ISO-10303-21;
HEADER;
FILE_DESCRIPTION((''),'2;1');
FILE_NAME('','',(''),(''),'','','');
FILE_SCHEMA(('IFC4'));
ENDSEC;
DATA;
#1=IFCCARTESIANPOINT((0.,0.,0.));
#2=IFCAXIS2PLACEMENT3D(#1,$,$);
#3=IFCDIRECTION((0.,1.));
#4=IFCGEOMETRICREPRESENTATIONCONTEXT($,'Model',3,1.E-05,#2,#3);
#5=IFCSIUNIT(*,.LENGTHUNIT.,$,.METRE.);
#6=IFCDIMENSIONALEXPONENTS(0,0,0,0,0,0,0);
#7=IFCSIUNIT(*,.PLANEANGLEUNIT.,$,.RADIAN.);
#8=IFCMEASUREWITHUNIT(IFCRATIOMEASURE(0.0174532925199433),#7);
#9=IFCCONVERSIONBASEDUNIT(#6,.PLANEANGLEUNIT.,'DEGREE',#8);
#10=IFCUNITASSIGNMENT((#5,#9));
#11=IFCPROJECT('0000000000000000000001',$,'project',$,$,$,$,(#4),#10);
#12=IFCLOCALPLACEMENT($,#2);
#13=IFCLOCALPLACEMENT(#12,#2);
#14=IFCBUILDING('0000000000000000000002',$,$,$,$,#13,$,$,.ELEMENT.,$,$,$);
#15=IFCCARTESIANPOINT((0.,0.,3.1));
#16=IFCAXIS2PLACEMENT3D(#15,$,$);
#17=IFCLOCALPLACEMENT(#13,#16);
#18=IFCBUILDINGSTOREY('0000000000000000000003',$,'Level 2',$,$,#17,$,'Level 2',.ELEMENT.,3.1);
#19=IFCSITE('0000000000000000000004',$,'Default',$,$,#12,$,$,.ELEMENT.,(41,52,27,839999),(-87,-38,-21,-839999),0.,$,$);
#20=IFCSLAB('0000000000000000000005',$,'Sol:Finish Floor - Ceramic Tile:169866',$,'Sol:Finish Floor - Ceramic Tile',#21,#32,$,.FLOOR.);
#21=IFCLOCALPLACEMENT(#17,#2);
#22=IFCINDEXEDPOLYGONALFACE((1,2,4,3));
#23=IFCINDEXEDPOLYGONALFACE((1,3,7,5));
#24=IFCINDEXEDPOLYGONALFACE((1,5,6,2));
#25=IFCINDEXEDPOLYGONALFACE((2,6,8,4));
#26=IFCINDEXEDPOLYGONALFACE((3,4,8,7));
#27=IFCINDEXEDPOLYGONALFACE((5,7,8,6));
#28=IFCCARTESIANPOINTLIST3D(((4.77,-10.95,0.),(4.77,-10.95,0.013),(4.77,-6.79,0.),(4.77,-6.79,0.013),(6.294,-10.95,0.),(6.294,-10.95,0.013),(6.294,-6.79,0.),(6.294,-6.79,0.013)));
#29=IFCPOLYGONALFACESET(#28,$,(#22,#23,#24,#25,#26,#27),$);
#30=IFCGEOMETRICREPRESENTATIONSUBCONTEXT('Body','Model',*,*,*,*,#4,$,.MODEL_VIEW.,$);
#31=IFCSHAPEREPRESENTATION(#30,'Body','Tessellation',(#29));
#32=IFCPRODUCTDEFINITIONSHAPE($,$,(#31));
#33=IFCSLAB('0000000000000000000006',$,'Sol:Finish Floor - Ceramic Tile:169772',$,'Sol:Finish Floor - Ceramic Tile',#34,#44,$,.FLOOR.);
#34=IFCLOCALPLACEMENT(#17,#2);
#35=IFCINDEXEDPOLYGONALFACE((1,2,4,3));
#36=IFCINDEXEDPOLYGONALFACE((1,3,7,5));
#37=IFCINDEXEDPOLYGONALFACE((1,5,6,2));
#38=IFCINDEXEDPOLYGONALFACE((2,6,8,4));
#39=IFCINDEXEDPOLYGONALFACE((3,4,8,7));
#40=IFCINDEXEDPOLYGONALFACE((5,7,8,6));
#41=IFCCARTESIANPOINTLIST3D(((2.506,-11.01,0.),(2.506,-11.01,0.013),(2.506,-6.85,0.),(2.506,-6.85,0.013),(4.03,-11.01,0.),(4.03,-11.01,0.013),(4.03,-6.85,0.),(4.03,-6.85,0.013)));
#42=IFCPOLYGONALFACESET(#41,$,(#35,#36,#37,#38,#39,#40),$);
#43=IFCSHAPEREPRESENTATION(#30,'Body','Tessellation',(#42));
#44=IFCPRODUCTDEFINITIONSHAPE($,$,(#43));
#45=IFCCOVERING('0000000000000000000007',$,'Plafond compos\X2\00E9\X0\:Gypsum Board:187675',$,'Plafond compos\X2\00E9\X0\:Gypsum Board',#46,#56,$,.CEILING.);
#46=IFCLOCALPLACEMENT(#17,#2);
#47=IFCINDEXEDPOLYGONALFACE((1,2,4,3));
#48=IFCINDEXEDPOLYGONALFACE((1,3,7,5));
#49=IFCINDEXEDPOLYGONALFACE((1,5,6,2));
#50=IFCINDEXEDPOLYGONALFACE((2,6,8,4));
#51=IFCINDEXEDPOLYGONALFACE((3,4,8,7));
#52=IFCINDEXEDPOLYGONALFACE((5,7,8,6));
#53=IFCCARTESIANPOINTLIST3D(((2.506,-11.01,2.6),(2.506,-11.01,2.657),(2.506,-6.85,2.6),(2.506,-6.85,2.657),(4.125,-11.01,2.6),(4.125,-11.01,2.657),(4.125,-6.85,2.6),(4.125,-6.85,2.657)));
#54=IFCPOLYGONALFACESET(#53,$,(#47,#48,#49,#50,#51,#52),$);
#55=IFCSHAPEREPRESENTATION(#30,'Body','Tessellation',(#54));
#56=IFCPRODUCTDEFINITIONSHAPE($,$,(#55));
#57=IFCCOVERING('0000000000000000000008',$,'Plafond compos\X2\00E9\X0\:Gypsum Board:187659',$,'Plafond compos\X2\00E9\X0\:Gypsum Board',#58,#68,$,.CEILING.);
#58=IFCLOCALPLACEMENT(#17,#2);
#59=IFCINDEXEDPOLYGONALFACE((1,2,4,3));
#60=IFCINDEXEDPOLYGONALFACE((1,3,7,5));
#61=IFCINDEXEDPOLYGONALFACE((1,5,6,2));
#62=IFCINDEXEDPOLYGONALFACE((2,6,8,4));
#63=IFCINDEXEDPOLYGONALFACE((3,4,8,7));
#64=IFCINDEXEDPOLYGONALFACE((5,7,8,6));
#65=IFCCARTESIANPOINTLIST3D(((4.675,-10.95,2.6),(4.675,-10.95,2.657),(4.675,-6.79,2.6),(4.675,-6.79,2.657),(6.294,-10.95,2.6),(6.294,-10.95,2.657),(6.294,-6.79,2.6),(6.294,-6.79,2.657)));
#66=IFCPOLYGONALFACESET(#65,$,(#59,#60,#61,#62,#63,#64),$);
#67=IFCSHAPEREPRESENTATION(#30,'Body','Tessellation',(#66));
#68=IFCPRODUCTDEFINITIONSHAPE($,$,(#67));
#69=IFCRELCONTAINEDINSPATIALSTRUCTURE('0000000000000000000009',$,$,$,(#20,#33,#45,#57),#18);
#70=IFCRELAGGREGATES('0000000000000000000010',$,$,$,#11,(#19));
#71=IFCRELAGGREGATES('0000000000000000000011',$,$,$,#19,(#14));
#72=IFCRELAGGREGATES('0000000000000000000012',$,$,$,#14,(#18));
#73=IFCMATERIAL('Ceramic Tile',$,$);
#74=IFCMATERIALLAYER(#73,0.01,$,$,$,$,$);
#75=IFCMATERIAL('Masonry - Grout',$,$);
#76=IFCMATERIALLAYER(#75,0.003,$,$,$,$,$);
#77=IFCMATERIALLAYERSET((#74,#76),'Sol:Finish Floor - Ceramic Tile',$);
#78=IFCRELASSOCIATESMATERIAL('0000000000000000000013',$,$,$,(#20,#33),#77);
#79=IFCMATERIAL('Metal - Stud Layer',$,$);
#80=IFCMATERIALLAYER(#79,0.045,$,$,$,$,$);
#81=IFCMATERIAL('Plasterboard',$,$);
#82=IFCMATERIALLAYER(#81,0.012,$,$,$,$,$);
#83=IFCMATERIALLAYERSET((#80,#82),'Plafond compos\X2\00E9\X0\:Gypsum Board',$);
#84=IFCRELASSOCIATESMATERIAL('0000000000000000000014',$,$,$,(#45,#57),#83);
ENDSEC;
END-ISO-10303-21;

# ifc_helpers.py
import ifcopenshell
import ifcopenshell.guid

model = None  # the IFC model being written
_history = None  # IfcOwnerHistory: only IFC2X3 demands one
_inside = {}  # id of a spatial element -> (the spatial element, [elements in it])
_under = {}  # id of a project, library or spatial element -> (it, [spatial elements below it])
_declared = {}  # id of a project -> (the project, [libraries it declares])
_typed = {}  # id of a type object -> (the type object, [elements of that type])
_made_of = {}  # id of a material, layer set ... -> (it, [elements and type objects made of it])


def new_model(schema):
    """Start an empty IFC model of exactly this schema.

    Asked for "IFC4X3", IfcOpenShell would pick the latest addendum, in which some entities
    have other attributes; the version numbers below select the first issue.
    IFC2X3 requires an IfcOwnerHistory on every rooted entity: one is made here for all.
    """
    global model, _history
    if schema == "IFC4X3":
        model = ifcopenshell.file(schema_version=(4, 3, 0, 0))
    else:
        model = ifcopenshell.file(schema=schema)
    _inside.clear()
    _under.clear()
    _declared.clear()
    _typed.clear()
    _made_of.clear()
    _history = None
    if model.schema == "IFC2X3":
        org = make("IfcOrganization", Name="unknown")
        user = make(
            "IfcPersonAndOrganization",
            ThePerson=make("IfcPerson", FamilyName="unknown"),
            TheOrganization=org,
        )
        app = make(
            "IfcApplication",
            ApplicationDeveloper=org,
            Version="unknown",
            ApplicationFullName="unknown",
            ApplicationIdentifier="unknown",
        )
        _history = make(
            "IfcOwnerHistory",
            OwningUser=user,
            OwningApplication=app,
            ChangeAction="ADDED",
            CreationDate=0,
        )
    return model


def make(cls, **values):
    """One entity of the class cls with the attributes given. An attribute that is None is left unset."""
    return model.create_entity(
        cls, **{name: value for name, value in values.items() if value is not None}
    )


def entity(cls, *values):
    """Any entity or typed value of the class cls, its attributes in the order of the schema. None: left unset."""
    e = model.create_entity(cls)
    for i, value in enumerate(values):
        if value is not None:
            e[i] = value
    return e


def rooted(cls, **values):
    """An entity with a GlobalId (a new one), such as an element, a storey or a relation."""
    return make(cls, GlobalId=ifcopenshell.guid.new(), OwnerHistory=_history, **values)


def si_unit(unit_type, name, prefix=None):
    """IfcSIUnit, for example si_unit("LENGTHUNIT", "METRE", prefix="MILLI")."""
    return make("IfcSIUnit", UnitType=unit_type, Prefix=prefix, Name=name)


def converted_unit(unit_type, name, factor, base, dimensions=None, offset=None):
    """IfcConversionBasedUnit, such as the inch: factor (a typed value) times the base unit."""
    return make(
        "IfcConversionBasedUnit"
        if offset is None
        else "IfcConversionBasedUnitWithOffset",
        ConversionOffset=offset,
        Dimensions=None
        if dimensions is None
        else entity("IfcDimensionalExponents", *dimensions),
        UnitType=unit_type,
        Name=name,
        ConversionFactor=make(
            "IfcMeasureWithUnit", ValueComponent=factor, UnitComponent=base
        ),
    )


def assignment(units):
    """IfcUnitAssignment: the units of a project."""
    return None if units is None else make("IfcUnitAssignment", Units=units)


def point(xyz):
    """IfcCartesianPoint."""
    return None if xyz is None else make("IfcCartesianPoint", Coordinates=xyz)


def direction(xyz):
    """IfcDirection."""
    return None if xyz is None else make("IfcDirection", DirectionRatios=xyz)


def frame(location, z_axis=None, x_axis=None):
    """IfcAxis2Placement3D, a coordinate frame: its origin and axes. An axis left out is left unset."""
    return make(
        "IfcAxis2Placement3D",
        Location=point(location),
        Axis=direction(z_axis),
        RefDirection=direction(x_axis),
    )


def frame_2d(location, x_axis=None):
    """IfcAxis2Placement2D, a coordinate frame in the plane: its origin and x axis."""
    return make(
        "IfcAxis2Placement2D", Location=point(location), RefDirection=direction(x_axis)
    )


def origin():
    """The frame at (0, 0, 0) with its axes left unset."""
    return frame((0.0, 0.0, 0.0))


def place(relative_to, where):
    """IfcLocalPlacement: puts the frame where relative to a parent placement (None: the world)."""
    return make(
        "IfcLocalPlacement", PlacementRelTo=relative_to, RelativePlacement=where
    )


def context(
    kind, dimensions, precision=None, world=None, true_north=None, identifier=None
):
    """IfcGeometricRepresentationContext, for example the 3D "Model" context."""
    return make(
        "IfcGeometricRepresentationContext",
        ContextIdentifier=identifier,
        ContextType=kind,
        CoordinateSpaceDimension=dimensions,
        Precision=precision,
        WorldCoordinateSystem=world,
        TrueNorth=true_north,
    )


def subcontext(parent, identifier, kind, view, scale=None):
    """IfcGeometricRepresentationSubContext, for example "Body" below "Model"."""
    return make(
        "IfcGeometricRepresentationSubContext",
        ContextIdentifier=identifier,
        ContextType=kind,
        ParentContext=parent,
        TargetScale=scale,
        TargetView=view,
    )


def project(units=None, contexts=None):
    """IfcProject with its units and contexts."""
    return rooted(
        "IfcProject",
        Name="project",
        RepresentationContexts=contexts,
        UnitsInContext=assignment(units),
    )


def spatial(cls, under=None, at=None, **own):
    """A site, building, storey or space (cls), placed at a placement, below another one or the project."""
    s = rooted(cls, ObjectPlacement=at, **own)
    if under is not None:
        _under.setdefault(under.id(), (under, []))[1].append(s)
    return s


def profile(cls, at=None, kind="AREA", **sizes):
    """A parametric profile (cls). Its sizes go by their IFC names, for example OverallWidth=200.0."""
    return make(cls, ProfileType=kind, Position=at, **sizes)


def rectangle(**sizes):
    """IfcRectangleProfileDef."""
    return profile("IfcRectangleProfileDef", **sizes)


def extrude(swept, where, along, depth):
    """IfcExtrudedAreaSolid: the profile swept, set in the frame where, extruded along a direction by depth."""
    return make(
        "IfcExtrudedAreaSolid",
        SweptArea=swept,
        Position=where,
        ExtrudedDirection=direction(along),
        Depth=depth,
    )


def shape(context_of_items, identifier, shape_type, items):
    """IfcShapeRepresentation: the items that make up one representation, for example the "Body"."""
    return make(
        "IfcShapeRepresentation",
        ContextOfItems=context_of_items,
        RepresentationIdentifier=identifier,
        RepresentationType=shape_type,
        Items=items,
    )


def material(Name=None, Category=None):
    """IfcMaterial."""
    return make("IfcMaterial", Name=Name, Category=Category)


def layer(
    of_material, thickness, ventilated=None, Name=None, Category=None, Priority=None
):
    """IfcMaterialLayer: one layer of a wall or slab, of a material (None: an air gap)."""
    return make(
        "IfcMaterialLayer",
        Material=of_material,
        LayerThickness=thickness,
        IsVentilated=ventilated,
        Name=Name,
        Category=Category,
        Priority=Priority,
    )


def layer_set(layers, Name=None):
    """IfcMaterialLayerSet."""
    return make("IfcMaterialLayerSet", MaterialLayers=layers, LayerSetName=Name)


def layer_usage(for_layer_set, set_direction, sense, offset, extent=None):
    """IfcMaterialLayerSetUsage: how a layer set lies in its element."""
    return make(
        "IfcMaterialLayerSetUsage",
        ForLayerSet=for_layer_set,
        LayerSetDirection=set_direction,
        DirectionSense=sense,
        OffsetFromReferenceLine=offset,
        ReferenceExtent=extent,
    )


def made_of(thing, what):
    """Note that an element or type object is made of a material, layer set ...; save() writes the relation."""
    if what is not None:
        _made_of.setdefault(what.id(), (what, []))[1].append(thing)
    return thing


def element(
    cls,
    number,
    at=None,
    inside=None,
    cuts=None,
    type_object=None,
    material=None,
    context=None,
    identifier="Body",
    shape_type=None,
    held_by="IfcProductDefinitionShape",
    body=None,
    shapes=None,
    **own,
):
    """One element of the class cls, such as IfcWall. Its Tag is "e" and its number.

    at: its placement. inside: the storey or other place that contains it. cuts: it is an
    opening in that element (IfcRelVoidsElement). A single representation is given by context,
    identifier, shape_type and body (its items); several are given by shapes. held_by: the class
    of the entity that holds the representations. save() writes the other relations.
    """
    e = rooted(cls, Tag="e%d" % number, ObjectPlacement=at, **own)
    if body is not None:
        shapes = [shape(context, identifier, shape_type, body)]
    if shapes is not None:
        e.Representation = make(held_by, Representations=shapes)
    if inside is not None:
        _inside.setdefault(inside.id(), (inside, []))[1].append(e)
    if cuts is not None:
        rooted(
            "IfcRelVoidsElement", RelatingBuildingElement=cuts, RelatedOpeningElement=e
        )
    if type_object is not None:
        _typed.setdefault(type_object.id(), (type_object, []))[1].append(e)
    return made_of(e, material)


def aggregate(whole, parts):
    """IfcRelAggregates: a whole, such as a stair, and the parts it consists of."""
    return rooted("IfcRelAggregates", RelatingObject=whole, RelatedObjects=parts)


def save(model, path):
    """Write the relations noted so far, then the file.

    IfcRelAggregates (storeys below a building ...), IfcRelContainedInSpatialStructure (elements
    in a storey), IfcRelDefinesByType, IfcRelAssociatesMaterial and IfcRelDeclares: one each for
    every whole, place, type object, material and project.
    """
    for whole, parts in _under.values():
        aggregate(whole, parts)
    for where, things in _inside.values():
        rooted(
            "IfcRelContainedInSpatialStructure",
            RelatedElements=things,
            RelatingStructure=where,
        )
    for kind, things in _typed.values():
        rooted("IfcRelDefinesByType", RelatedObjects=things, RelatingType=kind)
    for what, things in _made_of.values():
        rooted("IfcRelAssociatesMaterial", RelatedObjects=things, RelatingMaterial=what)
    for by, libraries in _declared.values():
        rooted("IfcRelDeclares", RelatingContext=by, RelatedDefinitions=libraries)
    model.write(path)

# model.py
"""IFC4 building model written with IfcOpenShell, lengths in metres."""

from ifc_helpers import new_model, entity, si_unit, converted_unit, direction, frame, frame_2d, origin, place, context, subcontext, project, spatial, rectangle, extrude, material, layer, layer_set, layer_usage, element, save


model = new_model("IFC4")

# Units and contexts
model_context = context("Model", 3, precision=1e-05, world=origin(), true_north=direction((0.0, 1.0)))
body_context = subcontext(model_context, "Body", "Model", "MODEL_VIEW")
ifc_project = project(units=[si_unit("LENGTHUNIT", "METRE"), converted_unit("PLANEANGLEUNIT", "DEGREE", entity("IfcRatioMeasure", 0.0174532925199433), si_unit("PLANEANGLEUNIT", "RADIAN"), dimensions=[0, 0, 0, 0, 0, 0, 0])], contexts=[model_context])

# Site, building, storey
site_placement = place(None, origin())
site = spatial("IfcSite", under=ifc_project, at=site_placement, Name="Default", CompositionType="ELEMENT", RefLatitude=(41, 52, 27, 839999), RefLongitude=(-87, -38, -21, -839999), RefElevation=0.0)
building_placement = place(site_placement, origin())
building = spatial("IfcBuilding", under=site, at=building_placement, CompositionType="ELEMENT")
storey_placement = place(building_placement, frame((0.0, 0.0, 3.1)))
storey = spatial("IfcBuildingStorey", under=building, at=storey_placement, Name="Level 2", LongName="Level 2", CompositionType="ELEMENT", Elevation=3.1)

# Slabs
ifc_material_1 = material(Name="Ceramic Tile")
ifc_layer_1 = layer(ifc_material_1, 0.01)
ifc_material_2 = material(Name="Masonry - Grout")
ifc_layer_2 = layer(ifc_material_2, 0.003)
ifc_layer_set_1 = layer_set([ifc_layer_1, ifc_layer_2], Name="Sol:Finish Floor - Ceramic Tile")
ifc_layer_usage_1 = layer_usage(ifc_layer_set_1, "AXIS3", "POSITIVE", 0.0)
slab_1_placement = place(storey_placement, origin())
element("IfcSlab", 1, at=slab_1_placement, inside=storey, material=ifc_layer_usage_1, Name="Sol:Finish Floor - Ceramic Tile:169866", ObjectType="Sol:Finish Floor - Ceramic Tile", PredefinedType="FLOOR", context=body_context, shape_type="SweptSolid", body=[
    extrude(rectangle(XDim=4.16, YDim=1.524, at=frame_2d((0.0, 0.0), x_axis=(1.0, 0.0))), frame((5.532, -8.87, 0.013), z_axis=(0.0, 0.0, -1.0), x_axis=(0.0, 1.0, 0.0)), (0.0, 0.0, 1.0), 0.013),
])
ifc_layer_usage_2 = layer_usage(ifc_layer_set_1, "AXIS3", "POSITIVE", 0.0)
slab_2_placement = place(storey_placement, origin())
element("IfcSlab", 2, at=slab_2_placement, inside=storey, material=ifc_layer_usage_2, Name="Sol:Finish Floor - Ceramic Tile:169772", ObjectType="Sol:Finish Floor - Ceramic Tile", PredefinedType="FLOOR", context=body_context, shape_type="SweptSolid", body=[
    extrude(rectangle(XDim=4.16, YDim=1.524, at=frame_2d((0.0, 0.0), x_axis=(1.0, 0.0))), frame((3.268, -8.93, 0.013), z_axis=(0.0, 0.0, -1.0), x_axis=(0.0, 1.0, 0.0)), (0.0, 0.0, 1.0), 0.013),
])

# Shared definitions
ifc_material_3 = material(Name="Metal - Stud Layer")
ifc_material_4 = material(Name="Plasterboard")

# Shared definitions
ifc_layer_3 = layer(ifc_material_3, 0.045)
ifc_layer_4 = layer(ifc_material_4, 0.012)
ifc_layer_set_2 = layer_set([ifc_layer_3, ifc_layer_4], Name="Plafond composé:Gypsum Board")

# Coverings
ifc_layer_usage_3 = layer_usage(ifc_layer_set_2, "AXIS3", "NEGATIVE", 0.0)
covering_1_placement = place(storey_placement, origin())
element("IfcCovering", 3, at=covering_1_placement, inside=storey, material=ifc_layer_usage_3, Name="Plafond composé:Gypsum Board:187675", ObjectType="Plafond composé:Gypsum Board", PredefinedType="CEILING", context=body_context, shape_type="SweptSolid", body=[
    extrude(rectangle(XDim=1.619, YDim=4.16, at=frame_2d((0.0, 0.0), x_axis=(1.0, 0.0))), frame((3.3155, -8.93, 2.6), z_axis=(0.0, 0.0, 1.0), x_axis=(-1.0, 0.0, 0.0)), (0.0, 0.0, 1.0), 0.057),
])
ifc_layer_usage_4 = layer_usage(ifc_layer_set_2, "AXIS3", "NEGATIVE", 0.0)
covering_2_placement = place(storey_placement, origin())
element("IfcCovering", 4, at=covering_2_placement, inside=storey, material=ifc_layer_usage_4, Name="Plafond composé:Gypsum Board:187659", ObjectType="Plafond composé:Gypsum Board", PredefinedType="CEILING", context=body_context, shape_type="SweptSolid", body=[
    extrude(rectangle(XDim=1.619, YDim=4.16, at=frame_2d((0.0, 0.0), x_axis=(1.0, 0.0))), frame((5.4845, -8.87, 2.6)), (0.0, 0.0, 1.0), 0.057),
])

save(model, "model.ifc")
